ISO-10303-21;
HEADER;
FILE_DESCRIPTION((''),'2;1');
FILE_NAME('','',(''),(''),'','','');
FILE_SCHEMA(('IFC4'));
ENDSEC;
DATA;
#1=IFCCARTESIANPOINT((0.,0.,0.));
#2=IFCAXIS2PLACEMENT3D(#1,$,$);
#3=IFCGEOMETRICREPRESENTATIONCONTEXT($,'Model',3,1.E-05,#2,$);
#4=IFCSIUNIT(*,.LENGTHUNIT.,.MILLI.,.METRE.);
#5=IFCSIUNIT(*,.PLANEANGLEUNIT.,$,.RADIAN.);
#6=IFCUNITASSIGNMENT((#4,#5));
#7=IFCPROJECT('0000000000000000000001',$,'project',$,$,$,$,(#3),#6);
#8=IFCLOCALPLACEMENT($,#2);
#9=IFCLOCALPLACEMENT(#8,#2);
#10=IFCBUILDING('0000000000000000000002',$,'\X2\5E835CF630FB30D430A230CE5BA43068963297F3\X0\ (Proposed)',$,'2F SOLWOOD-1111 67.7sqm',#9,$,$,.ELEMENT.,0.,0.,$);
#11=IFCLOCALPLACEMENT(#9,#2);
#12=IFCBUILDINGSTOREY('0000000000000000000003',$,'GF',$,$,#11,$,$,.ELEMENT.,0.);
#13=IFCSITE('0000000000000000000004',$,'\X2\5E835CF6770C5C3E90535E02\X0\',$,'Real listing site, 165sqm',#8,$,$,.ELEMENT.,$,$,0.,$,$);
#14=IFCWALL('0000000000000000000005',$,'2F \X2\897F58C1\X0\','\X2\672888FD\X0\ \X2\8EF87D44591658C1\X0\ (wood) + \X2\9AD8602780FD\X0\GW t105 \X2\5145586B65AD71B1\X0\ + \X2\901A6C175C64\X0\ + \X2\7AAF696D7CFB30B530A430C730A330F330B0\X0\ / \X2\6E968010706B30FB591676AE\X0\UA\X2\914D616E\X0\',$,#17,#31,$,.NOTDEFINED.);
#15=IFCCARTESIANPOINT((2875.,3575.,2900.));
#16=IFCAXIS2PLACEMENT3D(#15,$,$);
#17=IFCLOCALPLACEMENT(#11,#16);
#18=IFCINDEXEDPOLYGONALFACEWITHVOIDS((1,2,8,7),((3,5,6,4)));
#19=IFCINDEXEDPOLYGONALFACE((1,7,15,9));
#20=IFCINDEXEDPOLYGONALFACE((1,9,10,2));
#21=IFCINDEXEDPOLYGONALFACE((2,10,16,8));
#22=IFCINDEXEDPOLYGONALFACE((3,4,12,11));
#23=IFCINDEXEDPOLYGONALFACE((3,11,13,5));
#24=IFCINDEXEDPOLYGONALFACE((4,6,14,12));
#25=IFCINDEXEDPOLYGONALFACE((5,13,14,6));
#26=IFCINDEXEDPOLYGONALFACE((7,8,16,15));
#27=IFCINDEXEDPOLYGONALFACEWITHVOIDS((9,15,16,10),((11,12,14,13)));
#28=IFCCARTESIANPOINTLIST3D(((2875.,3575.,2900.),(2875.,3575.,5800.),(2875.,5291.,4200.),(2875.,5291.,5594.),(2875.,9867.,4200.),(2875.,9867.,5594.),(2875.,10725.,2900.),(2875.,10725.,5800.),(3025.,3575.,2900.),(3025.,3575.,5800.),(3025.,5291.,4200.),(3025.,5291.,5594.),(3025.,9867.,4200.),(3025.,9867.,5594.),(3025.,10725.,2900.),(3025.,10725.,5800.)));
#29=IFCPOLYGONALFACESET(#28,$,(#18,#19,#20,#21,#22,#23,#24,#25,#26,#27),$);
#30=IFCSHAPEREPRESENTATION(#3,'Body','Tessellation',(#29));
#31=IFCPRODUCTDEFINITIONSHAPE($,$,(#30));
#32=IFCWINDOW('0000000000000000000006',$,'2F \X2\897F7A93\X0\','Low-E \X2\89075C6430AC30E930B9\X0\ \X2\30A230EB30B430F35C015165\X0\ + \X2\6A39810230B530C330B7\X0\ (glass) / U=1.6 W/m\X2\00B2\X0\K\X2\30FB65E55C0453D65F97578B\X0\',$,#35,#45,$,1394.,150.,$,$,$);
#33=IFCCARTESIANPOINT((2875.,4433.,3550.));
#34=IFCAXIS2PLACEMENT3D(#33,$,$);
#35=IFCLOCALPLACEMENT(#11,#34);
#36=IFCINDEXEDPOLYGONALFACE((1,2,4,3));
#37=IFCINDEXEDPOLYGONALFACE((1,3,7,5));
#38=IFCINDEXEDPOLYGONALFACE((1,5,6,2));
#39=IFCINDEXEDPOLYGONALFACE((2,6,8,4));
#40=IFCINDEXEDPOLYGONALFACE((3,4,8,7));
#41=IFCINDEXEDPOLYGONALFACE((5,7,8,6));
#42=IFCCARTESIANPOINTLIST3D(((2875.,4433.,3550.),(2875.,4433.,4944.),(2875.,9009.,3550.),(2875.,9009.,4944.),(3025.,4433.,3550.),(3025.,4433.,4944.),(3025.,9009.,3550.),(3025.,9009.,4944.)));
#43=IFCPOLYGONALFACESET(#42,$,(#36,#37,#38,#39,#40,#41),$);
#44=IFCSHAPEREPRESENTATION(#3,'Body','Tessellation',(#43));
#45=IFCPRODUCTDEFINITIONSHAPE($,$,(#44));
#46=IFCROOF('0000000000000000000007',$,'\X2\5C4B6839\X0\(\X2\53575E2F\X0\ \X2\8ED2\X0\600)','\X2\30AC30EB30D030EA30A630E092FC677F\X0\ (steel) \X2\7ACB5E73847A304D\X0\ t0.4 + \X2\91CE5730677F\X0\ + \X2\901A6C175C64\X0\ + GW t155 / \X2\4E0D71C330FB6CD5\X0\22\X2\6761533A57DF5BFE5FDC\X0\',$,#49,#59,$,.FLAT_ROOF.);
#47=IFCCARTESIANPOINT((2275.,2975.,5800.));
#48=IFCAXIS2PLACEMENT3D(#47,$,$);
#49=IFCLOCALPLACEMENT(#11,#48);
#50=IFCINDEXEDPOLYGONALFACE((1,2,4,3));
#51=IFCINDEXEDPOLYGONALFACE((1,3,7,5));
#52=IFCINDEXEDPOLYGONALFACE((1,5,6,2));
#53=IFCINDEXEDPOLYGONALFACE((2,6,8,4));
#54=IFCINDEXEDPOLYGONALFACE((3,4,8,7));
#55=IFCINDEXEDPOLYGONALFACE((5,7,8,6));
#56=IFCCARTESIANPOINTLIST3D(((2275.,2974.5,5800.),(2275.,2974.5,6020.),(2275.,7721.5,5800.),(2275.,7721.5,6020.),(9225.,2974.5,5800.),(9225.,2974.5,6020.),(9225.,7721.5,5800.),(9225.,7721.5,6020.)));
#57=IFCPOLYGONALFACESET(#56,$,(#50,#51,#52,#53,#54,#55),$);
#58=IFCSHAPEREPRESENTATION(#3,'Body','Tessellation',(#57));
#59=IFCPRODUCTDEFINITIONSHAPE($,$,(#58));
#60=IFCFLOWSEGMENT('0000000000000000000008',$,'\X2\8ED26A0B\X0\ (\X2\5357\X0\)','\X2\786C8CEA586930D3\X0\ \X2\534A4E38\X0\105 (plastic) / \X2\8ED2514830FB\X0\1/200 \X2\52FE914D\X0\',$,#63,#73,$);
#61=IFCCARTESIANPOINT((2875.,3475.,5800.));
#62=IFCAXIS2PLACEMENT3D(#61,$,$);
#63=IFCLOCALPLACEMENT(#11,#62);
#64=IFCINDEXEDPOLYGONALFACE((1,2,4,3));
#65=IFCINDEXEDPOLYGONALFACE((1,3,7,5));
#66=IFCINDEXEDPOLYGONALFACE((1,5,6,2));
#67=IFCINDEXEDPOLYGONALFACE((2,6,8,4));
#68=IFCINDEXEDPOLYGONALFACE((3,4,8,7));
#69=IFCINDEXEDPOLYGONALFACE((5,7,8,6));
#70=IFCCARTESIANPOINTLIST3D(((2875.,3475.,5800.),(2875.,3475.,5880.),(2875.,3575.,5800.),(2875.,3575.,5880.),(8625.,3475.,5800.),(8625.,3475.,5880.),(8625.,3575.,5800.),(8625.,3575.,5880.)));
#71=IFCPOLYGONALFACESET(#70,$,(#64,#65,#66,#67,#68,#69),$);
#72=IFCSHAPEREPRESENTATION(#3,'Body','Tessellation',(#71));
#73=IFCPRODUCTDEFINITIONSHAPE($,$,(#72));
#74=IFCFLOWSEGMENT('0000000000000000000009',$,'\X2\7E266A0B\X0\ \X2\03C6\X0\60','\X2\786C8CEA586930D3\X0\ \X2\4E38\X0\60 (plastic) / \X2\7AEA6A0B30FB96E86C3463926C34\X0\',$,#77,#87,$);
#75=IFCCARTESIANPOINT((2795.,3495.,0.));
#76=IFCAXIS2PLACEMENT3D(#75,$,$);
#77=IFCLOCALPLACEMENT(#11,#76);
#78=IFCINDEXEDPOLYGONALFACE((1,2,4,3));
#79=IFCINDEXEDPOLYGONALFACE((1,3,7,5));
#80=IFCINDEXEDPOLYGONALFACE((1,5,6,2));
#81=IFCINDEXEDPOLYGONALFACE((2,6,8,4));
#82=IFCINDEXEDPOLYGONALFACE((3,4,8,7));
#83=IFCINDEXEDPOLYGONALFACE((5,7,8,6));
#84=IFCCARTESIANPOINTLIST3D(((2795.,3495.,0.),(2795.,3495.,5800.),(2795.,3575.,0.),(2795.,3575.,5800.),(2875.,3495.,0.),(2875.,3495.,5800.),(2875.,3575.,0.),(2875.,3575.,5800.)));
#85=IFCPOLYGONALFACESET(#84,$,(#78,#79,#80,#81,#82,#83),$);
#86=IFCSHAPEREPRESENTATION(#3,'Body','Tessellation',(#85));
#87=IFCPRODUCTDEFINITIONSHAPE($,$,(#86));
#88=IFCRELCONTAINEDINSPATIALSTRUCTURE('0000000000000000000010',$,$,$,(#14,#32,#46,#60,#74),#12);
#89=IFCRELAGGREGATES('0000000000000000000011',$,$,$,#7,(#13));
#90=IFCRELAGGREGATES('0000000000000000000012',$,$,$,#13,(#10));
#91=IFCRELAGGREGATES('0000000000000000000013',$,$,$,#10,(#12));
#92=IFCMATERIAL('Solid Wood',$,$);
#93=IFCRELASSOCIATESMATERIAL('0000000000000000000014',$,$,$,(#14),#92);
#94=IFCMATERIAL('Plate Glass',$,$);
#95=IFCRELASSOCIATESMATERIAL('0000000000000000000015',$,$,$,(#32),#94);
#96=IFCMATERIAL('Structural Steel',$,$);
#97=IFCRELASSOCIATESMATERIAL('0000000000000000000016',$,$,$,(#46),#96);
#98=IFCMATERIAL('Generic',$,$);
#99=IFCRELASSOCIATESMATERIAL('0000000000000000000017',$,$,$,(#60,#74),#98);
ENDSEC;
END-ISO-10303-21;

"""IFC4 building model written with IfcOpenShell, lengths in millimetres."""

from ifc_helpers import new_model, si_unit, frame, frame_2d, origin, place, context, project, spatial, rectangle, extrude, material, element, fill, save


model = new_model("IFC4")

# Units and contexts
model_context = context("Model", 3, precision=1e-05, world=origin())
ifc_project = project(units=[si_unit("LENGTHUNIT", "METRE", prefix="MILLI"), si_unit("PLANEANGLEUNIT", "RADIAN")], contexts=[model_context])

# Site, building, storey
site_placement = place(None, origin())
site = spatial("IfcSite", under=ifc_project, at=site_placement, Name="広島県尾道市", ObjectType="Real listing site, 165sqm", CompositionType="ELEMENT", RefElevation=0.0)
building_placement = place(site_placement, origin())
building = spatial("IfcBuilding", under=site, at=building_placement, Name="広島・ピアノ室と防音 (Proposed)", ObjectType="2F SOLWOOD-1111 67.7sqm", CompositionType="ELEMENT", ElevationOfRefHeight=0.0, ElevationOfTerrain=0.0)
storey_placement = place(building_placement, origin())
storey = spatial("IfcBuildingStorey", under=building, at=storey_placement, Name="GF", CompositionType="ELEMENT", Elevation=0.0)

# Shared definitions
ifc_material_1 = material(Name="Solid Wood")

# Shared definitions
ifc_material_2 = material(Name="Plate Glass")

# Wall, opening, window
wall_1_placement = place(storey_placement, frame((2875.0, 3575.0, 2900.0)))
wall_1 = element("IfcWall", 1, at=wall_1_placement, inside=storey, material=ifc_material_1, Name="2F 西壁", Description="木製 軸組外壁 (wood) + 高性能GW t105 充填断熱 + 通気層 + 窯業系サイディング / 準耐火・外皮UA配慮", PredefinedType="NOTDEFINED", context=model_context, shape_type="SweptSolid", body=[
    extrude(rectangle(XDim=150.0, YDim=7150.0, at=frame_2d((75.0, 3575.0))), frame((2875.0, 3575.0, 2900.0)), (0.0, 0.0, 1.0), 2900.0),
])
opening_1_placement = place(storey_placement, frame((2875.0, 4433.0, 3550.0)))
opening_1 = element("IfcOpeningElement", 2, at=opening_1_placement, cuts=wall_1, PredefinedType="NOTDEFINED", context=model_context, shape_type="SweptSolid", body=[
    extrude(rectangle(XDim=150.0, YDim=4576.0, at=frame_2d((75.0, 2288.0))), frame((2875.0, 4433.0, 3550.0)), (0.0, 0.0, 1.0), 1394.0),
])
window_1_placement = place(storey_placement, frame((2875.0, 4433.0, 3550.0)))
window_1 = element("IfcWindow", 3, at=window_1_placement, inside=storey, material=ifc_material_2, Name="2F 西窓", Description="Low-E 複層ガラス アルゴン封入 + 樹脂サッシ (glass) / U=1.6 W/m²K・日射取得型", OverallHeight=1394.0, OverallWidth=150.0, context=model_context, shape_type="SweptSolid", body=[
    extrude(rectangle(XDim=150.0, YDim=4576.0, at=frame_2d((75.0, 2288.0))), frame((2875.0, 4433.0, 3550.0)), (0.0, 0.0, 1.0), 1394.0),
])
fill(opening_1, window_1)

# Roof
ifc_material_3 = material(Name="Structural Steel")
for number, where, name in (
    (4, (2275.0, 2975.0, 5800.0), "屋根(南帯 軒600)"),
):
    element("IfcRoof", number, at=place(storey_placement, frame(where)), inside=storey, material=ifc_material_3, Name=name, Description="ガルバリウム鋼板 (steel) 立平葺き t0.4 + 野地板 + 通気層 + GW t155 / 不燃・法22条区域対応", PredefinedType="FLAT_ROOF", context=model_context, shape_type="SweptSolid", body=[
        extrude(rectangle(XDim=6950.0, YDim=4747.0, at=frame_2d((3475.0, 2373.0))), frame((2275.0, 2975.0, 5800.0)), (0.0, 0.0, 1.0), 220.0),
    ])

# Flow segments
ifc_material_4 = material(Name="Generic")
flow_segment_1_placement = place(storey_placement, frame((2875.0, 3475.0, 5800.0)))
element("IfcFlowSegment", 5, at=flow_segment_1_placement, inside=storey, material=ifc_material_4, Name="軒樋 (南)", Description="硬質塩ビ 半丸105 (plastic) / 軒先・1/200 勾配", context=model_context, shape_type="SweptSolid", body=[
    extrude(rectangle(XDim=5750.0, YDim=100.0, at=frame_2d((2875.0, 50.0))), frame((2875.0, 3475.0, 5800.0)), (0.0, 0.0, 1.0), 80.0),
])
flow_segment_2_placement = place(storey_placement, frame((2795.0, 3495.0, 0.0)))
element("IfcFlowSegment", 6, at=flow_segment_2_placement, inside=storey, material=ifc_material_4, Name="縦樋 φ60", Description="硬質塩ビ 丸60 (plastic) / 竪樋・雨水排水", context=model_context, shape_type="SweptSolid", body=[
    extrude(rectangle(XDim=80.0, YDim=80.0, at=frame_2d((40.0, 40.0))), frame((2795.0, 3495.0, 0.0)), (0.0, 0.0, 1.0), 5800.0),
])

save(model, "model.ifc")
